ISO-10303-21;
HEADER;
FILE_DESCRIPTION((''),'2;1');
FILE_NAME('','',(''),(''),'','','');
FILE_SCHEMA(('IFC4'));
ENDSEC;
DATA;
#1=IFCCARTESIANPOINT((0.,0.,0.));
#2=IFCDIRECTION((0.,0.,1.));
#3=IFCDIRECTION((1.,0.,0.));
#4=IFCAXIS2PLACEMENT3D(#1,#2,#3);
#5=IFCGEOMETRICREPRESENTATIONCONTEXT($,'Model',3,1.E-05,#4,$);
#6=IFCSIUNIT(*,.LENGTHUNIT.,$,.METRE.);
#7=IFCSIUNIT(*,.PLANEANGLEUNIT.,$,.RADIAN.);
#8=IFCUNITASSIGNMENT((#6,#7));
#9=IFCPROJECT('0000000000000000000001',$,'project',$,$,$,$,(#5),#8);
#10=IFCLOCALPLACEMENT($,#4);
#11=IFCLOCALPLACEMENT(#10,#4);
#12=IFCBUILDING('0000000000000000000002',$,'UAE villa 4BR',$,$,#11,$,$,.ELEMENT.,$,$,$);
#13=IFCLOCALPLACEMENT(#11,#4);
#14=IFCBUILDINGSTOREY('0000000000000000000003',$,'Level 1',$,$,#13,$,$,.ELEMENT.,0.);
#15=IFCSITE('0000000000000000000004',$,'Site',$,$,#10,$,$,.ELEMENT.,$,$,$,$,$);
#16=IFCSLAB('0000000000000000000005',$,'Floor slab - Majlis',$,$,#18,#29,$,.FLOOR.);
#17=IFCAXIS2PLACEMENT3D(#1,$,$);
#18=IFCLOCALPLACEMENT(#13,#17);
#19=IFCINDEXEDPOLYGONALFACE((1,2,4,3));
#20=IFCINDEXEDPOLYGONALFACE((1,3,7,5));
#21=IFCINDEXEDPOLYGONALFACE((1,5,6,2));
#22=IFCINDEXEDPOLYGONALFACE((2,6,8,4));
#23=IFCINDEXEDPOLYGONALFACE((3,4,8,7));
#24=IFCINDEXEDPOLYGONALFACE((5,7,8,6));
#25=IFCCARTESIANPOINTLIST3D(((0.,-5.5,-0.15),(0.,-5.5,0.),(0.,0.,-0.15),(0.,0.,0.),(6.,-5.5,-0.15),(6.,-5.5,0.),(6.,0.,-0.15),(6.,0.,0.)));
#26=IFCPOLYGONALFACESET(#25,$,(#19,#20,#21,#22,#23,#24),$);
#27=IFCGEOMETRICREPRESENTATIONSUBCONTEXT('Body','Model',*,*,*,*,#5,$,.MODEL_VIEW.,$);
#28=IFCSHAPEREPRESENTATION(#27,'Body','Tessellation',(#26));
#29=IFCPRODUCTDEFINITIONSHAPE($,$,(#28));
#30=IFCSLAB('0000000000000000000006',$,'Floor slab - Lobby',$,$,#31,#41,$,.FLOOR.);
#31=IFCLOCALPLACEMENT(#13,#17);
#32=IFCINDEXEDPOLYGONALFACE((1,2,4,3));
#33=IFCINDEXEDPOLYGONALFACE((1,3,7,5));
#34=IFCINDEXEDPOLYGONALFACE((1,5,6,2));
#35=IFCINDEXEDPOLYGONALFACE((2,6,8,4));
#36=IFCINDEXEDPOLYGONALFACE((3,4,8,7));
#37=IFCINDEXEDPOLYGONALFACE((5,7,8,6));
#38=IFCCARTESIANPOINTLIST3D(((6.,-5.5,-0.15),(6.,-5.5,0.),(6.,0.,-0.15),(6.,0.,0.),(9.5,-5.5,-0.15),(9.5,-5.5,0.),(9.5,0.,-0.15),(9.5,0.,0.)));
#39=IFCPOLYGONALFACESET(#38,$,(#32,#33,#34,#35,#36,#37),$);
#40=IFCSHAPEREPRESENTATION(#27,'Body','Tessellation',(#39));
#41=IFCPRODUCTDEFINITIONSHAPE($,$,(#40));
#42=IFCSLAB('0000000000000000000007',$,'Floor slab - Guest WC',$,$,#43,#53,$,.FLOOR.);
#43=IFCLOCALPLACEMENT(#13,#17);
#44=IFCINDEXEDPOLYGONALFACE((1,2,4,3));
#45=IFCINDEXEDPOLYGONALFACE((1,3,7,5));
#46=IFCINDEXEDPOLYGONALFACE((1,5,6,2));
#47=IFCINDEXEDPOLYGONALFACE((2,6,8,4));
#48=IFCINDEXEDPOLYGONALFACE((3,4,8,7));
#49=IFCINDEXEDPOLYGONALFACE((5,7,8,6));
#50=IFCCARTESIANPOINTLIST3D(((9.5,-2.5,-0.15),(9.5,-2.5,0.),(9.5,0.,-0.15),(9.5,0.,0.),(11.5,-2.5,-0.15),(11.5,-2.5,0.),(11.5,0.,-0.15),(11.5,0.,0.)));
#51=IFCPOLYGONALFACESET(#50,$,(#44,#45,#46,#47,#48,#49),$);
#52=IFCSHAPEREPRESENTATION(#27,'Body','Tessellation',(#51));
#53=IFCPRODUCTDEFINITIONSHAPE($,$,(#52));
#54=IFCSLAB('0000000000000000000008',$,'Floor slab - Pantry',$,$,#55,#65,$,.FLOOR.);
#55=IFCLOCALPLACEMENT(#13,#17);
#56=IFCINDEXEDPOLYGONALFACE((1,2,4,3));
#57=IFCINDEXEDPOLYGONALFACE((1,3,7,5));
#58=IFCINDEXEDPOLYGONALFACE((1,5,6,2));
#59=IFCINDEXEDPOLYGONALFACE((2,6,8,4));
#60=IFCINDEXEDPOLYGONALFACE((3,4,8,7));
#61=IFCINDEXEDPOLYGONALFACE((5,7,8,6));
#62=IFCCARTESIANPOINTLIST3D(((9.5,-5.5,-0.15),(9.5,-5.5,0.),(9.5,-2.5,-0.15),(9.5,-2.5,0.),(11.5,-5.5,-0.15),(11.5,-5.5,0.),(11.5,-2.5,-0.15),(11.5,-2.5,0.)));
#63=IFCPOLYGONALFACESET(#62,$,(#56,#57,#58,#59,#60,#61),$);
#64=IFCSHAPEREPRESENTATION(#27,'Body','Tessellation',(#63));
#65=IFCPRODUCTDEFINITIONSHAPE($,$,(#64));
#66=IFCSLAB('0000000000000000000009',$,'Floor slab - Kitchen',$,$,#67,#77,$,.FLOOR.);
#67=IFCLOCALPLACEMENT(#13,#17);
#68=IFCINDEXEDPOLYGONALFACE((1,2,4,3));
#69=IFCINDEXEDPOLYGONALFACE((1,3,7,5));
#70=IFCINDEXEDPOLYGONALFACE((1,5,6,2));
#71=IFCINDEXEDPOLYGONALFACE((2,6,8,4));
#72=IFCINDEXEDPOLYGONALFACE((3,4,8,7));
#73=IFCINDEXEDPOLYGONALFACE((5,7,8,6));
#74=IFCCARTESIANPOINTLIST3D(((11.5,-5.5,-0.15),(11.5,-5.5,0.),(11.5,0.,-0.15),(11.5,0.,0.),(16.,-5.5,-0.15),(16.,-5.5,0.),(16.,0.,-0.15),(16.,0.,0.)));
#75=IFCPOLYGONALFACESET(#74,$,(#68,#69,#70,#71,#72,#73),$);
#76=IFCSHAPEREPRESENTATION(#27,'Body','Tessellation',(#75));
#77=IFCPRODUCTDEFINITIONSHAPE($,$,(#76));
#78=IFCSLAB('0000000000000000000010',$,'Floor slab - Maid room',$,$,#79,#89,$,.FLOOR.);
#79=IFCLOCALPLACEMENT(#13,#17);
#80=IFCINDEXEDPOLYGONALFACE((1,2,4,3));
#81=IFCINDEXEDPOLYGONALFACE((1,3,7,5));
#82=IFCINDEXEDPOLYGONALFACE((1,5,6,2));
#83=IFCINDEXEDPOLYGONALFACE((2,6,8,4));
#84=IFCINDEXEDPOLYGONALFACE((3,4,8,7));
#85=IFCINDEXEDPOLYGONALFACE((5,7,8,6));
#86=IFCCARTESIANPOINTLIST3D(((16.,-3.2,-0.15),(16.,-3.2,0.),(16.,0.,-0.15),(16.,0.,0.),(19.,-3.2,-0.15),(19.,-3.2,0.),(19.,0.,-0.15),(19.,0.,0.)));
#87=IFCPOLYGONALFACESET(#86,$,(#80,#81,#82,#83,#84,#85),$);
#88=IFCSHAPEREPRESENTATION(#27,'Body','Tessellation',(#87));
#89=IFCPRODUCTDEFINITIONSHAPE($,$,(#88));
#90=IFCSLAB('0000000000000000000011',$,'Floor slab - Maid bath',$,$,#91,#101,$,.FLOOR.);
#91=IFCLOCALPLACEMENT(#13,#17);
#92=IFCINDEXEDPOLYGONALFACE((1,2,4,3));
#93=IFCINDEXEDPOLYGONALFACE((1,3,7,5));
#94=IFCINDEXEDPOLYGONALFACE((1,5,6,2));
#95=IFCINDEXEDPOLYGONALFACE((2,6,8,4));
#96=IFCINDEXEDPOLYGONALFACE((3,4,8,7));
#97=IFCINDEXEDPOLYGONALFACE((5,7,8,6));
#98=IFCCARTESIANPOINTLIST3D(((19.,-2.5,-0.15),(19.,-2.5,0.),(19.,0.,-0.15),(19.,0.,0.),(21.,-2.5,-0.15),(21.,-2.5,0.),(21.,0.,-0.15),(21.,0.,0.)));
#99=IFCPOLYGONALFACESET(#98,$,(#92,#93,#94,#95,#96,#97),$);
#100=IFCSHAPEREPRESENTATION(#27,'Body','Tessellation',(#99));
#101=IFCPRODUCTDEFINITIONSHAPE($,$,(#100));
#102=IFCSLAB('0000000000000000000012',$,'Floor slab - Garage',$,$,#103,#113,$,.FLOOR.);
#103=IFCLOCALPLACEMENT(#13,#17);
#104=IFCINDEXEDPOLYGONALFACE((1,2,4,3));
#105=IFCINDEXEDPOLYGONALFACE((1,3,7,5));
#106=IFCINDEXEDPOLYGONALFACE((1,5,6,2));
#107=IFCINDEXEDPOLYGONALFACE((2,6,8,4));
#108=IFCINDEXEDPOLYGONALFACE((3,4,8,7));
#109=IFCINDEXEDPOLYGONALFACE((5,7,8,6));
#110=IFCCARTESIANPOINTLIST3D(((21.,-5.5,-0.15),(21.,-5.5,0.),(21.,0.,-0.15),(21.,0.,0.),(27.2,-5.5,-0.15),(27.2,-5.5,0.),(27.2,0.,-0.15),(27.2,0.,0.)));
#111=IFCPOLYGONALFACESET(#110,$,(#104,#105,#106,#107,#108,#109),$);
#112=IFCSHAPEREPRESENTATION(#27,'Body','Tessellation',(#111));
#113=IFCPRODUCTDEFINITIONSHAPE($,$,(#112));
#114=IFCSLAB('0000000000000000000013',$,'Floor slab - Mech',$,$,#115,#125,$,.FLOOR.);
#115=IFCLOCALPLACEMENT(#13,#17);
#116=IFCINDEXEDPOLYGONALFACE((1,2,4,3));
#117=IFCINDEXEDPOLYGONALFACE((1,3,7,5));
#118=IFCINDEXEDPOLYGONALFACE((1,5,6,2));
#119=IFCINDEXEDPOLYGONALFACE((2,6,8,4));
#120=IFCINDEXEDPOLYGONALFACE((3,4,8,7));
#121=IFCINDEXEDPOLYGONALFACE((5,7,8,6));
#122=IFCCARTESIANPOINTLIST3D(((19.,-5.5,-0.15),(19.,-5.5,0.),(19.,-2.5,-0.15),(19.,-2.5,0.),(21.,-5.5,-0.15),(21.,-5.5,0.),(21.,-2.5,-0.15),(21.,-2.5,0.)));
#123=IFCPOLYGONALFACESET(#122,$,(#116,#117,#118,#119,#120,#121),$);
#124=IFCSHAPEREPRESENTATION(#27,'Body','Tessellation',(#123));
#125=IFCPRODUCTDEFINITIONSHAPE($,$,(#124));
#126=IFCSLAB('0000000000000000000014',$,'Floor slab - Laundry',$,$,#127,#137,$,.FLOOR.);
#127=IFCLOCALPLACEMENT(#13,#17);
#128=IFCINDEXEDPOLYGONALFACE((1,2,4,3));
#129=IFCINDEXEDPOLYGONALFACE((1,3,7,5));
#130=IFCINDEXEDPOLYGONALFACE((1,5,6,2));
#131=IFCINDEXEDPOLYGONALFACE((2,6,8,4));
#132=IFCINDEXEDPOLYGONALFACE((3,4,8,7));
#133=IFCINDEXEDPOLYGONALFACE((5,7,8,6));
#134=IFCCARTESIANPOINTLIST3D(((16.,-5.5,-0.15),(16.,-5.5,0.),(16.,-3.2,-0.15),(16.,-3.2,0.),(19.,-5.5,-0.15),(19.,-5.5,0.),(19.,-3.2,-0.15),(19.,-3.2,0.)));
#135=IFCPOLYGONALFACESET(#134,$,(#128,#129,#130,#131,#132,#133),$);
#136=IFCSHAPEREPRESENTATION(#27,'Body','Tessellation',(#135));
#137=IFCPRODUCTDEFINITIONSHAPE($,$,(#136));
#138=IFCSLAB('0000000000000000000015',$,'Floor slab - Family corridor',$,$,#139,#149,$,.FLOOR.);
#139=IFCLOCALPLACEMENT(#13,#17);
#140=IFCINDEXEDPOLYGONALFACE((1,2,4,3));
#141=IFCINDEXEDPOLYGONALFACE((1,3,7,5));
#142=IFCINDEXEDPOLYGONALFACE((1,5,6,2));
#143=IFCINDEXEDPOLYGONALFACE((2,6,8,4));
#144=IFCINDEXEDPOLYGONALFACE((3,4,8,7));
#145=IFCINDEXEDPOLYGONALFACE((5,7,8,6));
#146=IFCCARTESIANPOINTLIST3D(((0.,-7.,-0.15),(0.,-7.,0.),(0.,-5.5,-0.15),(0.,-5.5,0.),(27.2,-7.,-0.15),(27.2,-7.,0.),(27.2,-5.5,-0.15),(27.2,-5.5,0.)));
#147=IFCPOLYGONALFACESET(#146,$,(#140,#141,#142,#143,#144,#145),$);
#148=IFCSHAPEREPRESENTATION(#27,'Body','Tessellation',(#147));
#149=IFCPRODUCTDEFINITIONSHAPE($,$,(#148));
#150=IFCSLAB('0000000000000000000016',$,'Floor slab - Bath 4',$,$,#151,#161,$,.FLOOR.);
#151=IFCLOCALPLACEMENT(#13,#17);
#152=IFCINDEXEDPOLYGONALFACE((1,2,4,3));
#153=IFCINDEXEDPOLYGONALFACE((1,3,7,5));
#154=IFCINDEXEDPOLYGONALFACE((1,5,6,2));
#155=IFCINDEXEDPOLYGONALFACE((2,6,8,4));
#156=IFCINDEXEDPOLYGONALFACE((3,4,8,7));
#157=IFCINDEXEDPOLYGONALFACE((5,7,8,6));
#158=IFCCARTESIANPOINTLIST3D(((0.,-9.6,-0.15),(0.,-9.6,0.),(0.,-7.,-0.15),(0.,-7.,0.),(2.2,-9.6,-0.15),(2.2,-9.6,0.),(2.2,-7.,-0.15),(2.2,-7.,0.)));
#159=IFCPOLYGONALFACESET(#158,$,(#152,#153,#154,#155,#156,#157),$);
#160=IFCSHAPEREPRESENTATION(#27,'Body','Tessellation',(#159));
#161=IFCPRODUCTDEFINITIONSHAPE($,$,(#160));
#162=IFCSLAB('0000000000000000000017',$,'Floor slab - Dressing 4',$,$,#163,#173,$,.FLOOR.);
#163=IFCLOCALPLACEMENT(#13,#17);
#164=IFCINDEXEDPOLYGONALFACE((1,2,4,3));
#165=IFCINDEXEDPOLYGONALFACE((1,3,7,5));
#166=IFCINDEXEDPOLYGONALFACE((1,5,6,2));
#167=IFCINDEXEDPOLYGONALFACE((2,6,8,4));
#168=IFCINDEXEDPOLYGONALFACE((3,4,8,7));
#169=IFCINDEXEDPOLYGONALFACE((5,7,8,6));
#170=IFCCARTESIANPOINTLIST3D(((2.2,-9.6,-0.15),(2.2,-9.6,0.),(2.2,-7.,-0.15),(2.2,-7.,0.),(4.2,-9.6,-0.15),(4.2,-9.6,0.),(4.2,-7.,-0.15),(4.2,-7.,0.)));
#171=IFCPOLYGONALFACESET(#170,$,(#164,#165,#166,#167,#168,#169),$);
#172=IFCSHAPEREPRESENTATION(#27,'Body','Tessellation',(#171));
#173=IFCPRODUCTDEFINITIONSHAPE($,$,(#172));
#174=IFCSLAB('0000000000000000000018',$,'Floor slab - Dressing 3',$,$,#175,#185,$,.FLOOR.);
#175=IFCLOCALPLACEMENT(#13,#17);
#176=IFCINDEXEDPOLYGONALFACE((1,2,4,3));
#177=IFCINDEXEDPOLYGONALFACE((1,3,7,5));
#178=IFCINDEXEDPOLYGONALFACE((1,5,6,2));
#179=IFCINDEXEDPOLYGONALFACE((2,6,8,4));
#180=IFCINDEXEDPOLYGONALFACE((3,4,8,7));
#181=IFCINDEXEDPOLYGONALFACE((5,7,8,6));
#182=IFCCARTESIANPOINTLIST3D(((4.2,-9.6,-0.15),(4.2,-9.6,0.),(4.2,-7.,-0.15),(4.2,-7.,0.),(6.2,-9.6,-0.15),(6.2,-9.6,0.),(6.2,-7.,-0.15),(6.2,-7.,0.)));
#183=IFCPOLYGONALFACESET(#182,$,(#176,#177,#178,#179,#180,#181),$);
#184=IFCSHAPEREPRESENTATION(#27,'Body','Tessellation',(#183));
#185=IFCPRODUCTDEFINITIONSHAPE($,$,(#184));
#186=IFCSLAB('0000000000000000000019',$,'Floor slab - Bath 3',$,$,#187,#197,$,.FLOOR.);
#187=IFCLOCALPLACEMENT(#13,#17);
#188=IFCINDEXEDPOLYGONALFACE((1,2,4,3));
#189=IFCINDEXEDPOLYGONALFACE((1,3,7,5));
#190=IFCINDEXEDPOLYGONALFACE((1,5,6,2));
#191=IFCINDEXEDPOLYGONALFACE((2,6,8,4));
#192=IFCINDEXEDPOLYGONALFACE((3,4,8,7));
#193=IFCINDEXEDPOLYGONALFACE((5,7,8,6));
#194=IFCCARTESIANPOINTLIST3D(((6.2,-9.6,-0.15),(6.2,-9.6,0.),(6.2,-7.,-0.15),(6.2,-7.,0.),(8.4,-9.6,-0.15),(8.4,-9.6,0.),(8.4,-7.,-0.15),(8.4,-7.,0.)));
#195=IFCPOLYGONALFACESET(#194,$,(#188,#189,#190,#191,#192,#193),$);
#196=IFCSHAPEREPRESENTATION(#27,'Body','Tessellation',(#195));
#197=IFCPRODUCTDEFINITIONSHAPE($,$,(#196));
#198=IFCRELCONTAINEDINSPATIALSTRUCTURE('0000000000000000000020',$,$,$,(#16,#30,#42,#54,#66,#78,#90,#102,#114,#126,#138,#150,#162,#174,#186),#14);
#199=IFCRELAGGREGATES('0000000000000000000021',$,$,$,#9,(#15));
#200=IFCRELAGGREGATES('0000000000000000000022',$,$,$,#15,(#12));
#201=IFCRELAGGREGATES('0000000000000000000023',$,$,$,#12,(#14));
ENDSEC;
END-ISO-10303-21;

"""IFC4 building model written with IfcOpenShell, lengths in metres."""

from ifc_helpers import new_model, si_unit, frame, origin, origin_with_axes, place, context, subcontext, project, spatial, polyline, outline, extrude, element, save


model = new_model("IFC4")

# Units and contexts
model_context = context("Model", 3, precision=1e-05, world=origin_with_axes())
body_context = subcontext(model_context, "Body", "Model", "MODEL_VIEW")
ifc_project = project(units=[si_unit("LENGTHUNIT", "METRE"), si_unit("PLANEANGLEUNIT", "RADIAN")], contexts=[model_context])

# Site, building, storey
site_placement = place(None, origin_with_axes())
site = spatial("IfcSite", under=ifc_project, at=site_placement, Name="Site", CompositionType="ELEMENT")
building_placement = place(site_placement, origin_with_axes())
building = spatial("IfcBuilding", under=site, at=building_placement, Name="UAE villa 4BR", CompositionType="ELEMENT")
storey_placement = place(building_placement, origin_with_axes())
storey = spatial("IfcBuildingStorey", under=building, at=storey_placement, Name="Level 1", CompositionType="ELEMENT", Elevation=0.0)

# Slabs
slab_1_placement = place(storey_placement, frame((0.0, 0.0, -0.15), z_axis=(0.0, 0.0, 1.0), x_axis=(1.0, 0.0, 0.0)))
element("IfcSlab", 1, at=slab_1_placement, inside=storey, Name="Floor slab - Majlis", PredefinedType="FLOOR", context=body_context, shape_type="SweptSolid", body=[
    extrude(outline(polyline([(0.0, 0.0), (6.0, 0.0), (6.0, -5.5), (0.0, -5.5), (0.0, 0.0)])), origin(), (0.0, 0.0, 1.0), 0.15),
])
slab_2_placement = place(storey_placement, frame((0.0, 0.0, -0.15), z_axis=(0.0, 0.0, 1.0), x_axis=(1.0, 0.0, 0.0)))
element("IfcSlab", 2, at=slab_2_placement, inside=storey, Name="Floor slab - Lobby", PredefinedType="FLOOR", context=body_context, shape_type="SweptSolid", body=[
    extrude(outline(polyline([(6.0, 0.0), (9.5, 0.0), (9.5, -5.5), (6.0, -5.5), (6.0, 0.0)])), origin(), (0.0, 0.0, 1.0), 0.15),
])
slab_3_placement = place(storey_placement, frame((0.0, 0.0, -0.15), z_axis=(0.0, 0.0, 1.0), x_axis=(1.0, 0.0, 0.0)))
element("IfcSlab", 3, at=slab_3_placement, inside=storey, Name="Floor slab - Guest WC", PredefinedType="FLOOR", context=body_context, shape_type="SweptSolid", body=[
    extrude(outline(polyline([(9.5, 0.0), (11.5, 0.0), (11.5, -2.5), (9.5, -2.5), (9.5, 0.0)])), origin(), (0.0, 0.0, 1.0), 0.15),
])
slab_4_placement = place(storey_placement, frame((0.0, 0.0, -0.15), z_axis=(0.0, 0.0, 1.0), x_axis=(1.0, 0.0, 0.0)))
element("IfcSlab", 4, at=slab_4_placement, inside=storey, Name="Floor slab - Pantry", PredefinedType="FLOOR", context=body_context, shape_type="SweptSolid", body=[
    extrude(outline(polyline([(9.5, -2.5), (11.5, -2.5), (11.5, -5.5), (9.5, -5.5), (9.5, -2.5)])), origin(), (0.0, 0.0, 1.0), 0.15),
])
slab_5_placement = place(storey_placement, frame((0.0, 0.0, -0.15), z_axis=(0.0, 0.0, 1.0), x_axis=(1.0, 0.0, 0.0)))
element("IfcSlab", 5, at=slab_5_placement, inside=storey, Name="Floor slab - Kitchen", PredefinedType="FLOOR", context=body_context, shape_type="SweptSolid", body=[
    extrude(outline(polyline([(11.5, 0.0), (16.0, 0.0), (16.0, -5.5), (11.5, -5.5), (11.5, 0.0)])), origin(), (0.0, 0.0, 1.0), 0.15),
])
slab_6_placement = place(storey_placement, frame((0.0, 0.0, -0.15), z_axis=(0.0, 0.0, 1.0), x_axis=(1.0, 0.0, 0.0)))
element("IfcSlab", 6, at=slab_6_placement, inside=storey, Name="Floor slab - Maid room", PredefinedType="FLOOR", context=body_context, shape_type="SweptSolid", body=[
    extrude(outline(polyline([(16.0, 0.0), (19.0, 0.0), (19.0, -3.2), (16.0, -3.2), (16.0, 0.0)])), origin(), (0.0, 0.0, 1.0), 0.15),
])
slab_7_placement = place(storey_placement, frame((0.0, 0.0, -0.15), z_axis=(0.0, 0.0, 1.0), x_axis=(1.0, 0.0, 0.0)))
element("IfcSlab", 7, at=slab_7_placement, inside=storey, Name="Floor slab - Maid bath", PredefinedType="FLOOR", context=body_context, shape_type="SweptSolid", body=[
    extrude(outline(polyline([(19.0, 0.0), (21.0, 0.0), (21.0, -2.5), (19.0, -2.5), (19.0, 0.0)])), origin(), (0.0, 0.0, 1.0), 0.15),
])
slab_8_placement = place(storey_placement, frame((0.0, 0.0, -0.15), z_axis=(0.0, 0.0, 1.0), x_axis=(1.0, 0.0, 0.0)))
element("IfcSlab", 8, at=slab_8_placement, inside=storey, Name="Floor slab - Garage", PredefinedType="FLOOR", context=body_context, shape_type="SweptSolid", body=[
    extrude(outline(polyline([(21.0, 0.0), (27.2, 0.0), (27.2, -5.5), (21.0, -5.5), (21.0, 0.0)])), origin(), (0.0, 0.0, 1.0), 0.15),
])
slab_9_placement = place(storey_placement, frame((0.0, 0.0, -0.15), z_axis=(0.0, 0.0, 1.0), x_axis=(1.0, 0.0, 0.0)))
element("IfcSlab", 9, at=slab_9_placement, inside=storey, Name="Floor slab - Mech", PredefinedType="FLOOR", context=body_context, shape_type="SweptSolid", body=[
    extrude(outline(polyline([(19.0, -2.5), (21.0, -2.5), (21.0, -5.5), (19.0, -5.5), (19.0, -2.5)])), origin(), (0.0, 0.0, 1.0), 0.15),
])
slab_10_placement = place(storey_placement, frame((0.0, 0.0, -0.15), z_axis=(0.0, 0.0, 1.0), x_axis=(1.0, 0.0, 0.0)))
element("IfcSlab", 10, at=slab_10_placement, inside=storey, Name="Floor slab - Laundry", PredefinedType="FLOOR", context=body_context, shape_type="SweptSolid", body=[
    extrude(outline(polyline([(16.0, -3.2), (19.0, -3.2), (19.0, -5.5), (16.0, -5.5), (16.0, -3.2)])), origin(), (0.0, 0.0, 1.0), 0.15),
])
slab_11_placement = place(storey_placement, frame((0.0, 0.0, -0.15), z_axis=(0.0, 0.0, 1.0), x_axis=(1.0, 0.0, 0.0)))
element("IfcSlab", 11, at=slab_11_placement, inside=storey, Name="Floor slab - Family corridor", PredefinedType="FLOOR", context=body_context, shape_type="SweptSolid", body=[
    extrude(outline(polyline([(0.0, -5.5), (27.2, -5.5), (27.2, -7.0), (0.0, -7.0), (0.0, -5.5)])), origin(), (0.0, 0.0, 1.0), 0.15),
])
slab_12_placement = place(storey_placement, frame((0.0, 0.0, -0.15), z_axis=(0.0, 0.0, 1.0), x_axis=(1.0, 0.0, 0.0)))
element("IfcSlab", 12, at=slab_12_placement, inside=storey, Name="Floor slab - Bath 4", PredefinedType="FLOOR", context=body_context, shape_type="SweptSolid", body=[
    extrude(outline(polyline([(0.0, -7.0), (2.2, -7.0), (2.2, -9.6), (0.0, -9.6), (0.0, -7.0)])), origin(), (0.0, 0.0, 1.0), 0.15),
])
slab_13_placement = place(storey_placement, frame((0.0, 0.0, -0.15), z_axis=(0.0, 0.0, 1.0), x_axis=(1.0, 0.0, 0.0)))
element("IfcSlab", 13, at=slab_13_placement, inside=storey, Name="Floor slab - Dressing 4", PredefinedType="FLOOR", context=body_context, shape_type="SweptSolid", body=[
    extrude(outline(polyline([(2.2, -7.0), (4.2, -7.0), (4.2, -9.6), (2.2, -9.6), (2.2, -7.0)])), origin(), (0.0, 0.0, 1.0), 0.15),
])
slab_14_placement = place(storey_placement, frame((0.0, 0.0, -0.15), z_axis=(0.0, 0.0, 1.0), x_axis=(1.0, 0.0, 0.0)))
element("IfcSlab", 14, at=slab_14_placement, inside=storey, Name="Floor slab - Dressing 3", PredefinedType="FLOOR", context=body_context, shape_type="SweptSolid", body=[
    extrude(outline(polyline([(4.2, -7.0), (6.2, -7.0), (6.2, -9.6), (4.2, -9.6), (4.2, -7.0)])), origin(), (0.0, 0.0, 1.0), 0.15),
])
slab_15_placement = place(storey_placement, frame((0.0, 0.0, -0.15), z_axis=(0.0, 0.0, 1.0), x_axis=(1.0, 0.0, 0.0)))
element("IfcSlab", 15, at=slab_15_placement, inside=storey, Name="Floor slab - Bath 3", PredefinedType="FLOOR", context=body_context, shape_type="SweptSolid", body=[
    extrude(outline(polyline([(6.2, -7.0), (8.4, -7.0), (8.4, -9.6), (6.2, -9.6), (6.2, -7.0)])), origin(), (0.0, 0.0, 1.0), 0.15),
])

save(model, "model.ifc")
